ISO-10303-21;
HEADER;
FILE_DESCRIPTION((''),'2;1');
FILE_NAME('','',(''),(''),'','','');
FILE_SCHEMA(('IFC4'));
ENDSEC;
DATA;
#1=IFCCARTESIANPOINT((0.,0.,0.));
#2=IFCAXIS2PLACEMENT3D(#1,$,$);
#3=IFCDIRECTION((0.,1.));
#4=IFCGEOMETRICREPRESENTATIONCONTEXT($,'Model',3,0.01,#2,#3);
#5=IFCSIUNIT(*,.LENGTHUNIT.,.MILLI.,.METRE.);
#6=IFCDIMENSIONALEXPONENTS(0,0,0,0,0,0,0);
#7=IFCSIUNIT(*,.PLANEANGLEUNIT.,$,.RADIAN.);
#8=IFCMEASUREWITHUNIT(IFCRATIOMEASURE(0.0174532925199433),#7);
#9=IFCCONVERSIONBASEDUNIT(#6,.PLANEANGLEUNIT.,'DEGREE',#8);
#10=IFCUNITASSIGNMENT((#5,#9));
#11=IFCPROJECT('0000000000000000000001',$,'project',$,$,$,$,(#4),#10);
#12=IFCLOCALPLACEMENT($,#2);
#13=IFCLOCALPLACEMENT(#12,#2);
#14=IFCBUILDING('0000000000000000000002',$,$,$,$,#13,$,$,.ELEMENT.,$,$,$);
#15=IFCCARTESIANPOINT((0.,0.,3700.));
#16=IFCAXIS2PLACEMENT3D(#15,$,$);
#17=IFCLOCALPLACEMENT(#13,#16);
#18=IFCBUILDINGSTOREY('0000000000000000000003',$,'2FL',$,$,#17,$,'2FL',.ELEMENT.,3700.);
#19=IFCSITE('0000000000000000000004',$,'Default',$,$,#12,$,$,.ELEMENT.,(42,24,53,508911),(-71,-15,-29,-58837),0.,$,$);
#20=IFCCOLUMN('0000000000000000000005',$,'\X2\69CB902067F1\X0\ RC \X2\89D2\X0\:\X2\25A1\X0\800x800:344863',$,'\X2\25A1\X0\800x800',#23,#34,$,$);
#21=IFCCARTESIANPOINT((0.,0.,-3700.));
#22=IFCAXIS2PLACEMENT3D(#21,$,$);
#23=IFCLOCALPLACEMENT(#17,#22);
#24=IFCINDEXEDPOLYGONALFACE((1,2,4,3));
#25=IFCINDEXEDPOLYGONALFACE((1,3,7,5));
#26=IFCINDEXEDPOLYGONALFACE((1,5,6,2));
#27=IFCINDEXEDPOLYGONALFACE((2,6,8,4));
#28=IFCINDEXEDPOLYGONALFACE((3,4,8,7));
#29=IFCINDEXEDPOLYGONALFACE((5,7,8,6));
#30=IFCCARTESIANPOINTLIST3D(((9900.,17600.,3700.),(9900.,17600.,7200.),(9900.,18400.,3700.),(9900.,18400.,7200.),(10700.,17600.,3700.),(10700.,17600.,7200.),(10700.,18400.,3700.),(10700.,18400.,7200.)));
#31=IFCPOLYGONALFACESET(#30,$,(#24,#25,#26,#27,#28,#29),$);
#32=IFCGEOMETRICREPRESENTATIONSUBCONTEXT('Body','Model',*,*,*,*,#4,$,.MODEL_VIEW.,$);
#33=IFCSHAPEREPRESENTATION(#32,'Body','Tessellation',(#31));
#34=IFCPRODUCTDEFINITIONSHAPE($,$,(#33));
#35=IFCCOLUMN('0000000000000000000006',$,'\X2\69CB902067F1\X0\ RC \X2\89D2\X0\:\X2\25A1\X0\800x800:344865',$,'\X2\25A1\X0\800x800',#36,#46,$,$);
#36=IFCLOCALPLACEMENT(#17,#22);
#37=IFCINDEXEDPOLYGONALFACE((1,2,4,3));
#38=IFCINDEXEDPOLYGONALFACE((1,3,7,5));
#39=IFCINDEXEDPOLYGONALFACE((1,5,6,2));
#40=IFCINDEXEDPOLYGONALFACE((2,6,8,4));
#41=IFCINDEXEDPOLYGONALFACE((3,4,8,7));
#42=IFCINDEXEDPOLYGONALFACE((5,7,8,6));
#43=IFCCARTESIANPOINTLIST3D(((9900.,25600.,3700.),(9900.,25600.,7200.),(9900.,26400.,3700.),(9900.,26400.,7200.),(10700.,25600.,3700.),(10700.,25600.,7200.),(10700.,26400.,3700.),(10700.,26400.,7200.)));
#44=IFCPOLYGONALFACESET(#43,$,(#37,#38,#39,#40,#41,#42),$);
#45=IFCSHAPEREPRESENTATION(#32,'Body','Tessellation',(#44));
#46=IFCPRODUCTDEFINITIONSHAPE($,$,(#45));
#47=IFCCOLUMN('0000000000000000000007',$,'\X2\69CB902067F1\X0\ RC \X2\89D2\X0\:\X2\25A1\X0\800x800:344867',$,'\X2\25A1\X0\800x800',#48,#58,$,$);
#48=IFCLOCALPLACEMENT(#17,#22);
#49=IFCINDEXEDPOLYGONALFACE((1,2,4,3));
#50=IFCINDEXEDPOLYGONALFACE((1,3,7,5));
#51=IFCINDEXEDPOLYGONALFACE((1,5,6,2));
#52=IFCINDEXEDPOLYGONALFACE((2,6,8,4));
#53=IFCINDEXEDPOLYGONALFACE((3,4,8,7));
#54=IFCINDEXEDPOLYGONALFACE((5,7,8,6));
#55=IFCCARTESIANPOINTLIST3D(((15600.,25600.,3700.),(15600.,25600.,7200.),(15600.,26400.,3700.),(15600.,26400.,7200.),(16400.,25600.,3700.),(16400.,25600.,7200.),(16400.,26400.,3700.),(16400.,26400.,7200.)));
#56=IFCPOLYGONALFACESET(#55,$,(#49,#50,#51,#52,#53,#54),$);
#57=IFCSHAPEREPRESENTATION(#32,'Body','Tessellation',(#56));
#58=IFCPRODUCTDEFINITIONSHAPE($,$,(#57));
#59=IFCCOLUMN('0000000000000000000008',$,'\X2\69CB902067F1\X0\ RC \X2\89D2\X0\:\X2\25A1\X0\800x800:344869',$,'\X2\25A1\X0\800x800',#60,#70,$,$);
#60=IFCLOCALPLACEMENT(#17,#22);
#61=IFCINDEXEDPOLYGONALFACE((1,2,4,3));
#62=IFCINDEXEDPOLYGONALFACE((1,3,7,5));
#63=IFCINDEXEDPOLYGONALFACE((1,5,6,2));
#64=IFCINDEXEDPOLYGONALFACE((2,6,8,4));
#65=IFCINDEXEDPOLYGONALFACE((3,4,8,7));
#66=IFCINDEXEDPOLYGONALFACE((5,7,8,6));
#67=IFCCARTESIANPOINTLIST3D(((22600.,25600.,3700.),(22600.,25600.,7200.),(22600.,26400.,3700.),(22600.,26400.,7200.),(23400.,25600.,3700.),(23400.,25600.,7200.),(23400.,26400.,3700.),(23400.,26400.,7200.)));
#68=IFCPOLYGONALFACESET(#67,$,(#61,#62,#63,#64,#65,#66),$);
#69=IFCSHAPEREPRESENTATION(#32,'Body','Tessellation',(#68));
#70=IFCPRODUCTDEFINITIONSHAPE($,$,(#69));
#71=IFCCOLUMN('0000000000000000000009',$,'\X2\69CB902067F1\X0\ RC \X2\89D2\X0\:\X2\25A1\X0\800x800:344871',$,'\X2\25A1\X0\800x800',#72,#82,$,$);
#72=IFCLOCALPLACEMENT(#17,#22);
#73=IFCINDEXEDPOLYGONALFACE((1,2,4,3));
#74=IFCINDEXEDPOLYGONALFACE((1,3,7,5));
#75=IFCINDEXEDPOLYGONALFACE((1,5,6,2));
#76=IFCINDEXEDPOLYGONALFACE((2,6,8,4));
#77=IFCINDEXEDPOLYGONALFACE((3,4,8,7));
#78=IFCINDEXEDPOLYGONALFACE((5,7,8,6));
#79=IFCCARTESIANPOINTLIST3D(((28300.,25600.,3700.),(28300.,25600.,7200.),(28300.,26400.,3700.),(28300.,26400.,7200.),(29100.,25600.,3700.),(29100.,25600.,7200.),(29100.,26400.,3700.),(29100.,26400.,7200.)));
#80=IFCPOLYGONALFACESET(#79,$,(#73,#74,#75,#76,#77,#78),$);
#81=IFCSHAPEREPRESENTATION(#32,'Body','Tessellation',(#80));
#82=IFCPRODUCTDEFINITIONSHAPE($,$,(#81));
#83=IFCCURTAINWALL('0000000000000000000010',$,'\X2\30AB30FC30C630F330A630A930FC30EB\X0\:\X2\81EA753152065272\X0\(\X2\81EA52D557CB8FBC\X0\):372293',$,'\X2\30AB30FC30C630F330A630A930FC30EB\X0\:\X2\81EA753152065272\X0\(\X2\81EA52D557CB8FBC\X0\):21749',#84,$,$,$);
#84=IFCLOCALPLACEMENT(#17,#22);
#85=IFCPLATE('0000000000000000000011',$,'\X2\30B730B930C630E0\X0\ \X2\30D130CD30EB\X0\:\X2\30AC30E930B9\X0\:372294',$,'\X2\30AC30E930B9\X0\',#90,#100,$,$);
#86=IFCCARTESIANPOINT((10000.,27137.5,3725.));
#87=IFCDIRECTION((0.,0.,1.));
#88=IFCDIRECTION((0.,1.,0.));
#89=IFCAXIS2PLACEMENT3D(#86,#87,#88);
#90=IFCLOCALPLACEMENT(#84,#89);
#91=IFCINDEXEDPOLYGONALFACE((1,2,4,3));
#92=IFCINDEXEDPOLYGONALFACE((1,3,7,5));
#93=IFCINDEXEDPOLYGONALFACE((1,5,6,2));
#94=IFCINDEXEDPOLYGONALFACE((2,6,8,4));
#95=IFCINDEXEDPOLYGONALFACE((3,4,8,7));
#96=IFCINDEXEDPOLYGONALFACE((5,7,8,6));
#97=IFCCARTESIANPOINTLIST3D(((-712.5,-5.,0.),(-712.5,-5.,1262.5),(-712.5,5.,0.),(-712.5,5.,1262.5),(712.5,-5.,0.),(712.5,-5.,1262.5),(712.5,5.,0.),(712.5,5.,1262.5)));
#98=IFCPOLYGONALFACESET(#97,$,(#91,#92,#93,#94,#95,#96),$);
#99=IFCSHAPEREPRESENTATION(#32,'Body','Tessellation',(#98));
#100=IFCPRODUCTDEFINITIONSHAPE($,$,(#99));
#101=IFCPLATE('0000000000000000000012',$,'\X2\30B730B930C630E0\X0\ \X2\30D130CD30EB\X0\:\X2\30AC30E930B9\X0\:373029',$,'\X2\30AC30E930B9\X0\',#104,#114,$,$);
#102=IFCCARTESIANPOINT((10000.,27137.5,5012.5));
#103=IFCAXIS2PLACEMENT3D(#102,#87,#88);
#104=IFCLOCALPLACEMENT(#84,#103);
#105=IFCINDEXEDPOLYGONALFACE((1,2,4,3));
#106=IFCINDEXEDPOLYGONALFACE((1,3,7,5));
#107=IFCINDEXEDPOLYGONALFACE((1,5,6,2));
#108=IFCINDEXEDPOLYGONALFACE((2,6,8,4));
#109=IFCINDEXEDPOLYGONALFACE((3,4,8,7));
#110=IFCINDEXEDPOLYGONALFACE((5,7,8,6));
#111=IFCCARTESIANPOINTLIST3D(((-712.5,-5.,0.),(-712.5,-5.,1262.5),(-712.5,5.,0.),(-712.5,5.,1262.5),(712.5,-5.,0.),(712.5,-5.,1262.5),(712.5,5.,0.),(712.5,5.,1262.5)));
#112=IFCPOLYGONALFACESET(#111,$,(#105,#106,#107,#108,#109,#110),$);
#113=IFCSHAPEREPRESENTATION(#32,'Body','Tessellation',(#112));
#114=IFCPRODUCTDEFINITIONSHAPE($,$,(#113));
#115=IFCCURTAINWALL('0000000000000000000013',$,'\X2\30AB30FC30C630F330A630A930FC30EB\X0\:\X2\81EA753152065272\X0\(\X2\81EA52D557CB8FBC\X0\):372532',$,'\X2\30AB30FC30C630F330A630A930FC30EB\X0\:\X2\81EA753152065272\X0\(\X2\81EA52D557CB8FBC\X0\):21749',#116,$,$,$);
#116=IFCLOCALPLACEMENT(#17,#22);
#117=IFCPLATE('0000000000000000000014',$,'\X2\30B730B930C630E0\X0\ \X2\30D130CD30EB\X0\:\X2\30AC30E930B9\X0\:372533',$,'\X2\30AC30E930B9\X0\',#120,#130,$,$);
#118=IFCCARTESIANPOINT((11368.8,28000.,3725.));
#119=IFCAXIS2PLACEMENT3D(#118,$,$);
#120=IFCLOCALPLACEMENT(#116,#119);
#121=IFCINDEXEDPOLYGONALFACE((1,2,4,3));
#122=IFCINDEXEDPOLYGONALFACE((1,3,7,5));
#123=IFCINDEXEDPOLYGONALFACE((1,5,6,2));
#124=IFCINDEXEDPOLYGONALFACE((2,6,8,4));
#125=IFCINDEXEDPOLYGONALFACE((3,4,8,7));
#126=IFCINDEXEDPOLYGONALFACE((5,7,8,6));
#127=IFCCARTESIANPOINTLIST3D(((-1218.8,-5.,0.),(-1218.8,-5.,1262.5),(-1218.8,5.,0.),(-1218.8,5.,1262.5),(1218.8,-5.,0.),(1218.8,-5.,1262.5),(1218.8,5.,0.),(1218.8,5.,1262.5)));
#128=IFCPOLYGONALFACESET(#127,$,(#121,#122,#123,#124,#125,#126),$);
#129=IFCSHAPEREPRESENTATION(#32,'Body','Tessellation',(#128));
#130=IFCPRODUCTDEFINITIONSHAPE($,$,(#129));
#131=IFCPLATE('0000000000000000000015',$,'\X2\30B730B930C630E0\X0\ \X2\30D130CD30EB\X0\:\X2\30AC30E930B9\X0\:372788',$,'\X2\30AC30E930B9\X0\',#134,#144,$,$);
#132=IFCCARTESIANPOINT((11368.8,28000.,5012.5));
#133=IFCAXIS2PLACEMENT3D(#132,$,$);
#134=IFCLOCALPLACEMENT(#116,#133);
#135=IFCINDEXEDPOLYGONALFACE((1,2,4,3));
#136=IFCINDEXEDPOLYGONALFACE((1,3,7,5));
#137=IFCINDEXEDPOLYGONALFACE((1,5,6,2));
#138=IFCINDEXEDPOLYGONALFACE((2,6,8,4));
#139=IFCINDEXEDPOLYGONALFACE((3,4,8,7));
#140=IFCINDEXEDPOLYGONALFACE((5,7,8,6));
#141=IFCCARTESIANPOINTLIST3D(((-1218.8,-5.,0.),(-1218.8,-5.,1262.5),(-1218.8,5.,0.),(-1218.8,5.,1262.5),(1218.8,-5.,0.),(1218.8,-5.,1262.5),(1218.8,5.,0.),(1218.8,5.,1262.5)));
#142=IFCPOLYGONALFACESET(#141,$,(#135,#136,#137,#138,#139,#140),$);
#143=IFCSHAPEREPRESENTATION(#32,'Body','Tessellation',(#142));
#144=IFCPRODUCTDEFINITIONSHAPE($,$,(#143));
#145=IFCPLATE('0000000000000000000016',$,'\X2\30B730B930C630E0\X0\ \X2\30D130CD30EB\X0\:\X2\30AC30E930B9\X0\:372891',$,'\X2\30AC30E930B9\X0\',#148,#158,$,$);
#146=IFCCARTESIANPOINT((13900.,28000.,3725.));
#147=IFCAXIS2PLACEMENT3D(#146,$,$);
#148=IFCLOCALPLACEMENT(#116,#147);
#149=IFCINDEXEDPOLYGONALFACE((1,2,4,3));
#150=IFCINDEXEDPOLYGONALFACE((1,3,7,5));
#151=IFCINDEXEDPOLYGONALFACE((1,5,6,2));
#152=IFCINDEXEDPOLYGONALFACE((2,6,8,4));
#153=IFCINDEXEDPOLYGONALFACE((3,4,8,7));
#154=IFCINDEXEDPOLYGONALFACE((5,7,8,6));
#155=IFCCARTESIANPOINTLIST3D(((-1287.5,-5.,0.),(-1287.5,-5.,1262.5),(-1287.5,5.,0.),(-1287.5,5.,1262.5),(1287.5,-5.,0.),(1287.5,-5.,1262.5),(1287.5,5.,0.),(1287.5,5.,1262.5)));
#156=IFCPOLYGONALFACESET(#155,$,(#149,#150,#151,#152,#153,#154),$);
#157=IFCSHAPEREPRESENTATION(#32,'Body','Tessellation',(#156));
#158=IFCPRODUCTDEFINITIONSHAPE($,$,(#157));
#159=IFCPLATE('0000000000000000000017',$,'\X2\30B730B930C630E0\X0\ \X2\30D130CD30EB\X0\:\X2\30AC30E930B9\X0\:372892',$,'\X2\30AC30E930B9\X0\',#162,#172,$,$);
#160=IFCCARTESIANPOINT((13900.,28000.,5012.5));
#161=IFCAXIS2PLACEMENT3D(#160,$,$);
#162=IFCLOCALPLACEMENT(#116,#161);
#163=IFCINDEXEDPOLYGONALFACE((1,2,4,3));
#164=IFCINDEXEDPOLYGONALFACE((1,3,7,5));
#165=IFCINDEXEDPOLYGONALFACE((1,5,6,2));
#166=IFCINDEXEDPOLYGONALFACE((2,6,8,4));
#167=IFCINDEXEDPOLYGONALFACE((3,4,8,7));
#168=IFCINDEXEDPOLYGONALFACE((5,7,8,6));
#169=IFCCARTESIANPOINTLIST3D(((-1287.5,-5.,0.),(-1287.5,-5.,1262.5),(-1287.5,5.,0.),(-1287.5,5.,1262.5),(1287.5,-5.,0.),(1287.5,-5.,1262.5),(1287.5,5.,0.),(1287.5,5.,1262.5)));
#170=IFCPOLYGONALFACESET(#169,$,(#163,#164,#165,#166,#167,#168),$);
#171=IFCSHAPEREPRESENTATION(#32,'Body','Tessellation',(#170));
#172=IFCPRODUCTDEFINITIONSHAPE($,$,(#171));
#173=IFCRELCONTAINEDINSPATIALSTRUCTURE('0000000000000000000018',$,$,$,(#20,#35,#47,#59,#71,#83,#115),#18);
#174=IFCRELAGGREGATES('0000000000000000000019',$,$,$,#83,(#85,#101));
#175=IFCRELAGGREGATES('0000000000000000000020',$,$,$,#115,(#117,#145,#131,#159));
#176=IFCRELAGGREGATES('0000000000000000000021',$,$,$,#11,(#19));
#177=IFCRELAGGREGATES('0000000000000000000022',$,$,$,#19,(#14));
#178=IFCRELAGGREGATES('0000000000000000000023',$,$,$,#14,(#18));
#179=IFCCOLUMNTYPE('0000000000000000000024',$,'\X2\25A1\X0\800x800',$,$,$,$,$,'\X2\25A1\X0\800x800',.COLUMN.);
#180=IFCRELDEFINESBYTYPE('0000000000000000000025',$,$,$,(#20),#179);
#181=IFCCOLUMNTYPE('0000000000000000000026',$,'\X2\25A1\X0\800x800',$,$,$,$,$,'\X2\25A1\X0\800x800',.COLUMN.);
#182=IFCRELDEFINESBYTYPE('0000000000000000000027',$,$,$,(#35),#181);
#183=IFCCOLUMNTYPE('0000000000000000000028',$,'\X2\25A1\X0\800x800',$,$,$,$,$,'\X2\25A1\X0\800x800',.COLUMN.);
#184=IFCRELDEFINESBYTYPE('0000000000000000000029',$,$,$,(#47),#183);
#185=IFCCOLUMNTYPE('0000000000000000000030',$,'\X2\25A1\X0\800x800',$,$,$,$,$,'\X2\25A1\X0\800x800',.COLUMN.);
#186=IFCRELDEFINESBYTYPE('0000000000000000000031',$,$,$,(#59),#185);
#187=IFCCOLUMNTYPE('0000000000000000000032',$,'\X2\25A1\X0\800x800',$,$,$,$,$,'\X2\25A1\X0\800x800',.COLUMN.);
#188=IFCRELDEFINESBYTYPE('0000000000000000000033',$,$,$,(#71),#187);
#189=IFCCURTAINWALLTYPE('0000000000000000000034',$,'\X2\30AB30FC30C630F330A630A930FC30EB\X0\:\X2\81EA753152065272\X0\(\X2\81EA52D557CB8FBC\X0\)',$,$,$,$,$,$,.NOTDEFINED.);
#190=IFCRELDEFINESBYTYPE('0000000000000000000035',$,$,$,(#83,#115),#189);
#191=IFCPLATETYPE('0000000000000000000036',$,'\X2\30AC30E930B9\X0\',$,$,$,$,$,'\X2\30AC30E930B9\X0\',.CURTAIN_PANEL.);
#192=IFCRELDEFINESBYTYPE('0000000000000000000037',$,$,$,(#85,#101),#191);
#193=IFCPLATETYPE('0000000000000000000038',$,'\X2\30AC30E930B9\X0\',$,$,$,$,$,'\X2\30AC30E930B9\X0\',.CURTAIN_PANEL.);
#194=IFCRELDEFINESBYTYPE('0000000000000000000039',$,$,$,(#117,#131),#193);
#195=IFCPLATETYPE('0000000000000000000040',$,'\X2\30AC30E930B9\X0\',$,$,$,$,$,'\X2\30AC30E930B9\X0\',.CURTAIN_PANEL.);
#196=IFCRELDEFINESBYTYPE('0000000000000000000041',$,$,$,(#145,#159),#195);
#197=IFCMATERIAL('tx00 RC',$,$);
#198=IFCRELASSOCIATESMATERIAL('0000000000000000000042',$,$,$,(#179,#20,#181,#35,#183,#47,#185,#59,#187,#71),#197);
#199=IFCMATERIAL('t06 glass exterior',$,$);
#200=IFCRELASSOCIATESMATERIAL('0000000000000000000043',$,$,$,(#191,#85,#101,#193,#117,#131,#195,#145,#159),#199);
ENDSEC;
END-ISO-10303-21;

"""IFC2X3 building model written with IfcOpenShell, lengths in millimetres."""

from ifc_helpers import new_model, entity, si_unit, converted_unit, direction, frame, frame_2d, origin, origin_2d_with_axis, place, context, subcontext, project, spatial, rectangle, extrude, source, transform, mapped, material, type_object, type_shapes, element, aggregate, save


model = new_model("IFC2X3")

# Units and contexts
model_context = context("Model", 3, precision=0.01, world=origin(), true_north=direction((0.0, 1.0)))
body_context = subcontext(model_context, "Body", "Model", "MODEL_VIEW")
ifc_project = project(units=[si_unit("LENGTHUNIT", "METRE", prefix="MILLI"), converted_unit("PLANEANGLEUNIT", "DEGREE", entity("IfcRatioMeasure", 0.0174532925199433), si_unit("PLANEANGLEUNIT", "RADIAN"), dimensions=[0, 0, 0, 0, 0, 0, 0])], contexts=[model_context])

# Site, building, storey
site_placement = place(None, origin())
site = spatial("IfcSite", under=ifc_project, at=site_placement, Name="Default", CompositionType="ELEMENT", RefLatitude=(42, 24, 53, 508911), RefLongitude=(-71, -15, -29, -58837), RefElevation=0.0)
building_placement = place(site_placement, origin())
building = spatial("IfcBuilding", under=site, at=building_placement, CompositionType="ELEMENT")
storey_placement = place(building_placement, frame((0.0, 0.0, 3700.0)))
storey = spatial("IfcBuildingStorey", under=building, at=storey_placement, Name="2FL", LongName="2FL", CompositionType="ELEMENT", Elevation=3700.0)

# Columns
ifc_material_1 = material(Name="tx00 RC")
column_type_1 = type_object("IfcColumnType", Name="□800x800", ElementType="□800x800", PredefinedType="COLUMN", material=ifc_material_1)
shared_shape_1 = source(origin(), body_context, "Body", "SweptSolid", [
    extrude(rectangle(XDim=800.0, YDim=800.0, at=frame_2d((0.0, 0.0), x_axis=(1.0, 0.0))), frame((10300.0, 18000.0, 3700.0), z_axis=(0.0, 0.0, 1.0), x_axis=(0.0, -1.0, 0.0)), (0.0, 0.0, 1.0), 3500.0),
])
type_shapes(column_type_1, [shared_shape_1])
column_1_placement = place(storey_placement, frame((0.0, 0.0, -3700.0)))
element("IfcColumn", 1, at=column_1_placement, inside=storey, type_object=column_type_1, material=ifc_material_1, Name="構造柱 RC 角:□800x800:344863", ObjectType="□800x800", context=body_context, shape_type="MappedRepresentation", body=[
    mapped(shared_shape_1, transform((0.0, 0.0, 0.0), scale=1.0)),
])
column_type_2 = type_object("IfcColumnType", Name="□800x800", ElementType="□800x800", PredefinedType="COLUMN", material=ifc_material_1)
shared_shape_2 = source(origin(), body_context, "Body", "SweptSolid", [
    extrude(rectangle(XDim=800.0, YDim=800.0, at=frame_2d((0.0, 0.0), x_axis=(1.0, 0.0))), frame((10300.0, 26000.0, 3700.0), z_axis=(0.0, 0.0, 1.0), x_axis=(0.0, -1.0, 0.0)), (0.0, 0.0, 1.0), 3500.0),
])
type_shapes(column_type_2, [shared_shape_2])
column_2_placement = place(storey_placement, frame((0.0, 0.0, -3700.0)))
element("IfcColumn", 2, at=column_2_placement, inside=storey, type_object=column_type_2, material=ifc_material_1, Name="構造柱 RC 角:□800x800:344865", ObjectType="□800x800", context=body_context, shape_type="MappedRepresentation", body=[
    mapped(shared_shape_2, transform((0.0, 0.0, 0.0), scale=1.0)),
])
column_type_3 = type_object("IfcColumnType", Name="□800x800", ElementType="□800x800", PredefinedType="COLUMN", material=ifc_material_1)
shared_shape_3 = source(origin(), body_context, "Body", "SweptSolid", [
    extrude(rectangle(XDim=800.0, YDim=800.0, at=frame_2d((0.0, 0.0), x_axis=(1.0, 0.0))), frame((16000.0, 26000.0, 3700.0), z_axis=(0.0, 0.0, 1.0), x_axis=(0.0, -1.0, 0.0)), (0.0, 0.0, 1.0), 3500.0),
])
type_shapes(column_type_3, [shared_shape_3])
column_3_placement = place(storey_placement, frame((0.0, 0.0, -3700.0)))
element("IfcColumn", 3, at=column_3_placement, inside=storey, type_object=column_type_3, material=ifc_material_1, Name="構造柱 RC 角:□800x800:344867", ObjectType="□800x800", context=body_context, shape_type="MappedRepresentation", body=[
    mapped(shared_shape_3, transform((0.0, 0.0, 0.0), scale=1.0)),
])
column_type_4 = type_object("IfcColumnType", Name="□800x800", ElementType="□800x800", PredefinedType="COLUMN", material=ifc_material_1)
shared_shape_4 = source(origin(), body_context, "Body", "SweptSolid", [
    extrude(rectangle(XDim=800.0, YDim=800.0, at=origin_2d_with_axis()), frame((23000.0, 26000.0, 3700.0), z_axis=(0.0, 0.0, 1.0), x_axis=(0.0, -1.0, 0.0)), (0.0, 0.0, 1.0), 3500.0),
])
type_shapes(column_type_4, [shared_shape_4])
column_4_placement = place(storey_placement, frame((0.0, 0.0, -3700.0)))
element("IfcColumn", 4, at=column_4_placement, inside=storey, type_object=column_type_4, material=ifc_material_1, Name="構造柱 RC 角:□800x800:344869", ObjectType="□800x800", context=body_context, shape_type="MappedRepresentation", body=[
    mapped(shared_shape_4, transform((0.0, 0.0, 0.0), scale=1.0)),
])
column_type_5 = type_object("IfcColumnType", Name="□800x800", ElementType="□800x800", PredefinedType="COLUMN", material=ifc_material_1)
shared_shape_5 = source(origin(), body_context, "Body", "SweptSolid", [
    extrude(rectangle(XDim=800.0, YDim=800.0, at=origin_2d_with_axis()), frame((28700.0, 26000.0, 3700.0), z_axis=(0.0, 0.0, 1.0), x_axis=(0.0, -1.0, 0.0)), (0.0, 0.0, 1.0), 3500.0),
])
type_shapes(column_type_5, [shared_shape_5])
column_5_placement = place(storey_placement, frame((0.0, 0.0, -3700.0)))
element("IfcColumn", 5, at=column_5_placement, inside=storey, type_object=column_type_5, material=ifc_material_1, Name="構造柱 RC 角:□800x800:344871", ObjectType="□800x800", context=body_context, shape_type="MappedRepresentation", body=[
    mapped(shared_shape_5, transform((0.0, 0.0, 0.0), scale=1.0)),
])

# Curtain walls, plates
curtain_wall_type = type_object("IfcCurtainWallType", Name="カーテンウォール:自由分割(自動埋込)", PredefinedType="NOTDEFINED")
curtain_wall_1_placement = place(storey_placement, frame((0.0, 0.0, -3700.0)))
curtain_wall_1 = element("IfcCurtainWall", 6, at=curtain_wall_1_placement, inside=storey, type_object=curtain_wall_type, Name="カーテンウォール:自由分割(自動埋込):372293", ObjectType="カーテンウォール:自由分割(自動埋込):21749")
ifc_material_2 = material(Name="t06 glass exterior")
plate_type_1 = type_object("IfcPlateType", Name="ガラス", ElementType="ガラス", PredefinedType="CURTAIN_PANEL", material=ifc_material_2)
shared_shape_6 = source(origin(), body_context, "Body", "SweptSolid", [
    extrude(rectangle(XDim=10.0, YDim=1425.0, at=origin_2d_with_axis()), frame((0.0, 0.0, 0.0), z_axis=(0.0, 0.0, 1.0), x_axis=(0.0, 1.0, 0.0)), (0.0, 0.0, 1.0), 1262.5),
])
type_shapes(plate_type_1, [shared_shape_6])
plate_1_placement = place(curtain_wall_1_placement, frame((10000.0, 27137.5, 3725.0), z_axis=(0.0, 0.0, 1.0), x_axis=(0.0, 1.0, 0.0)))
plate_1 = element("IfcPlate", 7, at=plate_1_placement, type_object=plate_type_1, material=ifc_material_2, Name="システム パネル:ガラス:372294", ObjectType="ガラス", context=body_context, shape_type="MappedRepresentation", body=[
    mapped(shared_shape_6, transform((0.0, 0.0, 0.0), scale=1.0)),
])
plate_2_placement = place(curtain_wall_1_placement, frame((10000.0, 27137.5, 5012.5), z_axis=(0.0, 0.0, 1.0), x_axis=(0.0, 1.0, 0.0)))
plate_2 = element("IfcPlate", 8, at=plate_2_placement, type_object=plate_type_1, material=ifc_material_2, Name="システム パネル:ガラス:373029", ObjectType="ガラス", context=body_context, shape_type="MappedRepresentation", body=[
    mapped(shared_shape_6, transform((0.0, 0.0, 0.0), scale=1.0)),
])
aggregate(curtain_wall_1, [plate_1, plate_2])
curtain_wall_2_placement = place(storey_placement, frame((0.0, 0.0, -3700.0)))
curtain_wall_2 = element("IfcCurtainWall", 9, at=curtain_wall_2_placement, inside=storey, type_object=curtain_wall_type, Name="カーテンウォール:自由分割(自動埋込):372532", ObjectType="カーテンウォール:自由分割(自動埋込):21749")
plate_type_2 = type_object("IfcPlateType", Name="ガラス", ElementType="ガラス", PredefinedType="CURTAIN_PANEL", material=ifc_material_2)
shared_shape_7 = source(origin(), body_context, "Body", "SweptSolid", [
    extrude(rectangle(XDim=10.0, YDim=2437.5, at=origin_2d_with_axis()), frame((0.0, 0.0, 0.0), z_axis=(0.0, 0.0, 1.0), x_axis=(0.0, 1.0, 0.0)), (0.0, 0.0, 1.0), 1262.5),
])
type_shapes(plate_type_2, [shared_shape_7])
plate_3_placement = place(curtain_wall_2_placement, frame((11368.8, 28000.0, 3725.0)))
plate_3 = element("IfcPlate", 10, at=plate_3_placement, type_object=plate_type_2, material=ifc_material_2, Name="システム パネル:ガラス:372533", ObjectType="ガラス", context=body_context, shape_type="MappedRepresentation", body=[
    mapped(shared_shape_7, transform((0.0, 0.0, 0.0), scale=1.0)),
])
plate_4_placement = place(curtain_wall_2_placement, frame((11368.8, 28000.0, 5012.5)))
plate_4 = element("IfcPlate", 11, at=plate_4_placement, type_object=plate_type_2, material=ifc_material_2, Name="システム パネル:ガラス:372788", ObjectType="ガラス", context=body_context, shape_type="MappedRepresentation", body=[
    mapped(shared_shape_7, transform((0.0, 0.0, 0.0), scale=1.0)),
])
plate_type_3 = type_object("IfcPlateType", Name="ガラス", ElementType="ガラス", PredefinedType="CURTAIN_PANEL", material=ifc_material_2)
shared_shape_8 = source(origin(), body_context, "Body", "SweptSolid", [
    extrude(rectangle(XDim=10.0, YDim=2575.0, at=origin_2d_with_axis()), frame((0.0, 0.0, 0.0), z_axis=(0.0, 0.0, 1.0), x_axis=(0.0, 1.0, 0.0)), (0.0, 0.0, 1.0), 1262.5),
])
type_shapes(plate_type_3, [shared_shape_8])
plate_5_placement = place(curtain_wall_2_placement, frame((13900.0, 28000.0, 3725.0)))
plate_5 = element("IfcPlate", 12, at=plate_5_placement, type_object=plate_type_3, material=ifc_material_2, Name="システム パネル:ガラス:372891", ObjectType="ガラス", context=body_context, shape_type="MappedRepresentation", body=[
    mapped(shared_shape_8, transform((0.0, 0.0, 0.0), scale=1.0)),
])
plate_6_placement = place(curtain_wall_2_placement, frame((13900.0, 28000.0, 5012.5)))
plate_6 = element("IfcPlate", 13, at=plate_6_placement, type_object=plate_type_3, material=ifc_material_2, Name="システム パネル:ガラス:372892", ObjectType="ガラス", context=body_context, shape_type="MappedRepresentation", body=[
    mapped(shared_shape_8, transform((0.0, 0.0, 0.0), scale=1.0)),
])
aggregate(curtain_wall_2, [plate_3, plate_5, plate_4, plate_6])

save(model, "model.ifc")
